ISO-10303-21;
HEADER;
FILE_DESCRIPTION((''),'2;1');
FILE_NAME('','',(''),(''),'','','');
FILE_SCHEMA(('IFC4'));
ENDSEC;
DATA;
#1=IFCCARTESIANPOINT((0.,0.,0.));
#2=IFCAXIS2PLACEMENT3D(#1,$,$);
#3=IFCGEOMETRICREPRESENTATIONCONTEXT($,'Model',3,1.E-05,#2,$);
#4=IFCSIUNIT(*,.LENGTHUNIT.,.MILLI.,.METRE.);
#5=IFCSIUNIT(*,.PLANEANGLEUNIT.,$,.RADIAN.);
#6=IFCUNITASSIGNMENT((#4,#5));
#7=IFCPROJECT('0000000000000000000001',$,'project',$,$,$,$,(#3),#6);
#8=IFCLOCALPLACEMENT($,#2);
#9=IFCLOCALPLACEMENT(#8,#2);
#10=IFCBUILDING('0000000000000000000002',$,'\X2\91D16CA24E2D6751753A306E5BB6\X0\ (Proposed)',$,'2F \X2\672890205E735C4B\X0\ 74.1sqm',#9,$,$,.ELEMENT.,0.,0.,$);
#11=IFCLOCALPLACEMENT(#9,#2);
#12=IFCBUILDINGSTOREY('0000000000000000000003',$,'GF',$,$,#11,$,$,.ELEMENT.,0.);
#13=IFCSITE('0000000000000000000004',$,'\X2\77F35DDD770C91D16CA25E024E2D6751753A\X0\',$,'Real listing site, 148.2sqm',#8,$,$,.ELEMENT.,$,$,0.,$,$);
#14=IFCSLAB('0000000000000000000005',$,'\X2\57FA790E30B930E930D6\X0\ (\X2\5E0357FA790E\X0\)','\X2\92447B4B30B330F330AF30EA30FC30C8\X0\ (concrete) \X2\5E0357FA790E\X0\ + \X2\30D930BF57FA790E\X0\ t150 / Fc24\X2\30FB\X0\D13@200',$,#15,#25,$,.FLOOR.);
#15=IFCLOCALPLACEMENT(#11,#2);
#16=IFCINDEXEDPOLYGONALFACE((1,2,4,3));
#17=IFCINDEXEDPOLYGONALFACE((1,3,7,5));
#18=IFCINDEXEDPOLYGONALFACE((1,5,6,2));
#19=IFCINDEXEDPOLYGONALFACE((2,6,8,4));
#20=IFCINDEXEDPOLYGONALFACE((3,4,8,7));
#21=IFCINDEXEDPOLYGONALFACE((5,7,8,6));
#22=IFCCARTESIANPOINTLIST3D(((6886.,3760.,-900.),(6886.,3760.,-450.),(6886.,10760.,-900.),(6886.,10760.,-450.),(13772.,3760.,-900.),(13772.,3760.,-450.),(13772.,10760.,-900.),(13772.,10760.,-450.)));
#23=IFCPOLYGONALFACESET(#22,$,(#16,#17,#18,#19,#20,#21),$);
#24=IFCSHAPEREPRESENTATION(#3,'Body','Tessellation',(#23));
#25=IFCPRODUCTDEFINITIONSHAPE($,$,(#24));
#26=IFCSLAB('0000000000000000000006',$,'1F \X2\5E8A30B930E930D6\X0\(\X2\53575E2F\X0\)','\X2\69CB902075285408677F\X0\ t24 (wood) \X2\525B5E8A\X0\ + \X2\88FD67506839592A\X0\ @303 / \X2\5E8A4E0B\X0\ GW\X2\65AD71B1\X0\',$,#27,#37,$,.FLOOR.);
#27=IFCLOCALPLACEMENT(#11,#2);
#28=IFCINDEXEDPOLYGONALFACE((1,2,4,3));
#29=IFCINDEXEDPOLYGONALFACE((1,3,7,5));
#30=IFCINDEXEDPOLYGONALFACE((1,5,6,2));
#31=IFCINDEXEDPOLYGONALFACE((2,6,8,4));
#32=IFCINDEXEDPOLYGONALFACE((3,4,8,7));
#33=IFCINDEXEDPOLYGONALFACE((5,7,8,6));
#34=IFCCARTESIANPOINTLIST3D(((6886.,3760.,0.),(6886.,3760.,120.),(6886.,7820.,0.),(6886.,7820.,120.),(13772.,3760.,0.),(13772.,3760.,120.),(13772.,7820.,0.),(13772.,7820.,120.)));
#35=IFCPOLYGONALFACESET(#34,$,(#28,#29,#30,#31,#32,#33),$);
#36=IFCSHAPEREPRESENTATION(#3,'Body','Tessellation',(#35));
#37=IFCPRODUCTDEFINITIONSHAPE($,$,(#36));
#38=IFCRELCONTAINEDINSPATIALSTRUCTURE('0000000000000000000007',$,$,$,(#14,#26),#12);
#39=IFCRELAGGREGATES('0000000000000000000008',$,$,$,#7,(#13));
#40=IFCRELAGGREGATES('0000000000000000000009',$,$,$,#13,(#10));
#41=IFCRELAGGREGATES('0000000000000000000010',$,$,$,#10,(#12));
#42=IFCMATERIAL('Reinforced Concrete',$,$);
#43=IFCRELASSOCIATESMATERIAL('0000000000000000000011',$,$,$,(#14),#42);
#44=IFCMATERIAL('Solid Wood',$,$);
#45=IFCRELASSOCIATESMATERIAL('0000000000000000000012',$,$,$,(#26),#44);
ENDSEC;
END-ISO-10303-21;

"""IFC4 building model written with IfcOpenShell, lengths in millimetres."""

from ifc_helpers import new_model, si_unit, frame, frame_2d, origin, place, context, project, spatial, rectangle, extrude, material, element, save


model = new_model("IFC4")

# Units and contexts
model_context = context("Model", 3, precision=1e-05, world=origin())
ifc_project = project(units=[si_unit("LENGTHUNIT", "METRE", prefix="MILLI"), si_unit("PLANEANGLEUNIT", "RADIAN")], contexts=[model_context])

# Site, building, storey
site_placement = place(None, origin())
site = spatial("IfcSite", under=ifc_project, at=site_placement, Name="石川県金沢市中村町", ObjectType="Real listing site, 148.2sqm", CompositionType="ELEMENT", RefElevation=0.0)
building_placement = place(site_placement, origin())
building = spatial("IfcBuilding", under=site, at=building_placement, Name="金沢中村町の家 (Proposed)", ObjectType="2F 木造平屋 74.1sqm", CompositionType="ELEMENT", ElevationOfRefHeight=0.0, ElevationOfTerrain=0.0)
storey_placement = place(building_placement, origin())
storey = spatial("IfcBuildingStorey", under=building, at=storey_placement, Name="GF", CompositionType="ELEMENT", Elevation=0.0)

# Slabs
ifc_material_1 = material(Name="Reinforced Concrete")
slab_1_placement = place(storey_placement, frame((3443.0, 1880.0, -450.0)))
element("IfcSlab", 1, at=slab_1_placement, inside=storey, material=ifc_material_1, Name="基礎スラブ (布基礎)", Description="鉄筋コンクリート (concrete) 布基礎 + ベタ基礎 t150 / Fc24・D13@200", PredefinedType="FLOOR", context=model_context, shape_type="SweptSolid", body=[
    extrude(rectangle(XDim=6886.0, YDim=7000.0, at=frame_2d((3443.0, 3500.0))), frame((3443.0, 1880.0, -450.0)), (0.0, 0.0, 1.0), 450.0),
])
ifc_material_2 = material(Name="Solid Wood")
slab_2_placement = place(storey_placement, frame((3443.0, 1880.0, 0.0)))
element("IfcSlab", 2, at=slab_2_placement, inside=storey, material=ifc_material_2, Name="1F 床スラブ(南帯)", Description="構造用合板 t24 (wood) 剛床 + 製材根太 @303 / 床下 GW断熱", PredefinedType="FLOOR", context=model_context, shape_type="SweptSolid", body=[
    extrude(rectangle(XDim=6886.0, YDim=4060.0, at=frame_2d((3443.0, 2030.0))), frame((3443.0, 1880.0, 0.0)), (0.0, 0.0, 1.0), 120.0),
])

save(model, "model.ifc")
